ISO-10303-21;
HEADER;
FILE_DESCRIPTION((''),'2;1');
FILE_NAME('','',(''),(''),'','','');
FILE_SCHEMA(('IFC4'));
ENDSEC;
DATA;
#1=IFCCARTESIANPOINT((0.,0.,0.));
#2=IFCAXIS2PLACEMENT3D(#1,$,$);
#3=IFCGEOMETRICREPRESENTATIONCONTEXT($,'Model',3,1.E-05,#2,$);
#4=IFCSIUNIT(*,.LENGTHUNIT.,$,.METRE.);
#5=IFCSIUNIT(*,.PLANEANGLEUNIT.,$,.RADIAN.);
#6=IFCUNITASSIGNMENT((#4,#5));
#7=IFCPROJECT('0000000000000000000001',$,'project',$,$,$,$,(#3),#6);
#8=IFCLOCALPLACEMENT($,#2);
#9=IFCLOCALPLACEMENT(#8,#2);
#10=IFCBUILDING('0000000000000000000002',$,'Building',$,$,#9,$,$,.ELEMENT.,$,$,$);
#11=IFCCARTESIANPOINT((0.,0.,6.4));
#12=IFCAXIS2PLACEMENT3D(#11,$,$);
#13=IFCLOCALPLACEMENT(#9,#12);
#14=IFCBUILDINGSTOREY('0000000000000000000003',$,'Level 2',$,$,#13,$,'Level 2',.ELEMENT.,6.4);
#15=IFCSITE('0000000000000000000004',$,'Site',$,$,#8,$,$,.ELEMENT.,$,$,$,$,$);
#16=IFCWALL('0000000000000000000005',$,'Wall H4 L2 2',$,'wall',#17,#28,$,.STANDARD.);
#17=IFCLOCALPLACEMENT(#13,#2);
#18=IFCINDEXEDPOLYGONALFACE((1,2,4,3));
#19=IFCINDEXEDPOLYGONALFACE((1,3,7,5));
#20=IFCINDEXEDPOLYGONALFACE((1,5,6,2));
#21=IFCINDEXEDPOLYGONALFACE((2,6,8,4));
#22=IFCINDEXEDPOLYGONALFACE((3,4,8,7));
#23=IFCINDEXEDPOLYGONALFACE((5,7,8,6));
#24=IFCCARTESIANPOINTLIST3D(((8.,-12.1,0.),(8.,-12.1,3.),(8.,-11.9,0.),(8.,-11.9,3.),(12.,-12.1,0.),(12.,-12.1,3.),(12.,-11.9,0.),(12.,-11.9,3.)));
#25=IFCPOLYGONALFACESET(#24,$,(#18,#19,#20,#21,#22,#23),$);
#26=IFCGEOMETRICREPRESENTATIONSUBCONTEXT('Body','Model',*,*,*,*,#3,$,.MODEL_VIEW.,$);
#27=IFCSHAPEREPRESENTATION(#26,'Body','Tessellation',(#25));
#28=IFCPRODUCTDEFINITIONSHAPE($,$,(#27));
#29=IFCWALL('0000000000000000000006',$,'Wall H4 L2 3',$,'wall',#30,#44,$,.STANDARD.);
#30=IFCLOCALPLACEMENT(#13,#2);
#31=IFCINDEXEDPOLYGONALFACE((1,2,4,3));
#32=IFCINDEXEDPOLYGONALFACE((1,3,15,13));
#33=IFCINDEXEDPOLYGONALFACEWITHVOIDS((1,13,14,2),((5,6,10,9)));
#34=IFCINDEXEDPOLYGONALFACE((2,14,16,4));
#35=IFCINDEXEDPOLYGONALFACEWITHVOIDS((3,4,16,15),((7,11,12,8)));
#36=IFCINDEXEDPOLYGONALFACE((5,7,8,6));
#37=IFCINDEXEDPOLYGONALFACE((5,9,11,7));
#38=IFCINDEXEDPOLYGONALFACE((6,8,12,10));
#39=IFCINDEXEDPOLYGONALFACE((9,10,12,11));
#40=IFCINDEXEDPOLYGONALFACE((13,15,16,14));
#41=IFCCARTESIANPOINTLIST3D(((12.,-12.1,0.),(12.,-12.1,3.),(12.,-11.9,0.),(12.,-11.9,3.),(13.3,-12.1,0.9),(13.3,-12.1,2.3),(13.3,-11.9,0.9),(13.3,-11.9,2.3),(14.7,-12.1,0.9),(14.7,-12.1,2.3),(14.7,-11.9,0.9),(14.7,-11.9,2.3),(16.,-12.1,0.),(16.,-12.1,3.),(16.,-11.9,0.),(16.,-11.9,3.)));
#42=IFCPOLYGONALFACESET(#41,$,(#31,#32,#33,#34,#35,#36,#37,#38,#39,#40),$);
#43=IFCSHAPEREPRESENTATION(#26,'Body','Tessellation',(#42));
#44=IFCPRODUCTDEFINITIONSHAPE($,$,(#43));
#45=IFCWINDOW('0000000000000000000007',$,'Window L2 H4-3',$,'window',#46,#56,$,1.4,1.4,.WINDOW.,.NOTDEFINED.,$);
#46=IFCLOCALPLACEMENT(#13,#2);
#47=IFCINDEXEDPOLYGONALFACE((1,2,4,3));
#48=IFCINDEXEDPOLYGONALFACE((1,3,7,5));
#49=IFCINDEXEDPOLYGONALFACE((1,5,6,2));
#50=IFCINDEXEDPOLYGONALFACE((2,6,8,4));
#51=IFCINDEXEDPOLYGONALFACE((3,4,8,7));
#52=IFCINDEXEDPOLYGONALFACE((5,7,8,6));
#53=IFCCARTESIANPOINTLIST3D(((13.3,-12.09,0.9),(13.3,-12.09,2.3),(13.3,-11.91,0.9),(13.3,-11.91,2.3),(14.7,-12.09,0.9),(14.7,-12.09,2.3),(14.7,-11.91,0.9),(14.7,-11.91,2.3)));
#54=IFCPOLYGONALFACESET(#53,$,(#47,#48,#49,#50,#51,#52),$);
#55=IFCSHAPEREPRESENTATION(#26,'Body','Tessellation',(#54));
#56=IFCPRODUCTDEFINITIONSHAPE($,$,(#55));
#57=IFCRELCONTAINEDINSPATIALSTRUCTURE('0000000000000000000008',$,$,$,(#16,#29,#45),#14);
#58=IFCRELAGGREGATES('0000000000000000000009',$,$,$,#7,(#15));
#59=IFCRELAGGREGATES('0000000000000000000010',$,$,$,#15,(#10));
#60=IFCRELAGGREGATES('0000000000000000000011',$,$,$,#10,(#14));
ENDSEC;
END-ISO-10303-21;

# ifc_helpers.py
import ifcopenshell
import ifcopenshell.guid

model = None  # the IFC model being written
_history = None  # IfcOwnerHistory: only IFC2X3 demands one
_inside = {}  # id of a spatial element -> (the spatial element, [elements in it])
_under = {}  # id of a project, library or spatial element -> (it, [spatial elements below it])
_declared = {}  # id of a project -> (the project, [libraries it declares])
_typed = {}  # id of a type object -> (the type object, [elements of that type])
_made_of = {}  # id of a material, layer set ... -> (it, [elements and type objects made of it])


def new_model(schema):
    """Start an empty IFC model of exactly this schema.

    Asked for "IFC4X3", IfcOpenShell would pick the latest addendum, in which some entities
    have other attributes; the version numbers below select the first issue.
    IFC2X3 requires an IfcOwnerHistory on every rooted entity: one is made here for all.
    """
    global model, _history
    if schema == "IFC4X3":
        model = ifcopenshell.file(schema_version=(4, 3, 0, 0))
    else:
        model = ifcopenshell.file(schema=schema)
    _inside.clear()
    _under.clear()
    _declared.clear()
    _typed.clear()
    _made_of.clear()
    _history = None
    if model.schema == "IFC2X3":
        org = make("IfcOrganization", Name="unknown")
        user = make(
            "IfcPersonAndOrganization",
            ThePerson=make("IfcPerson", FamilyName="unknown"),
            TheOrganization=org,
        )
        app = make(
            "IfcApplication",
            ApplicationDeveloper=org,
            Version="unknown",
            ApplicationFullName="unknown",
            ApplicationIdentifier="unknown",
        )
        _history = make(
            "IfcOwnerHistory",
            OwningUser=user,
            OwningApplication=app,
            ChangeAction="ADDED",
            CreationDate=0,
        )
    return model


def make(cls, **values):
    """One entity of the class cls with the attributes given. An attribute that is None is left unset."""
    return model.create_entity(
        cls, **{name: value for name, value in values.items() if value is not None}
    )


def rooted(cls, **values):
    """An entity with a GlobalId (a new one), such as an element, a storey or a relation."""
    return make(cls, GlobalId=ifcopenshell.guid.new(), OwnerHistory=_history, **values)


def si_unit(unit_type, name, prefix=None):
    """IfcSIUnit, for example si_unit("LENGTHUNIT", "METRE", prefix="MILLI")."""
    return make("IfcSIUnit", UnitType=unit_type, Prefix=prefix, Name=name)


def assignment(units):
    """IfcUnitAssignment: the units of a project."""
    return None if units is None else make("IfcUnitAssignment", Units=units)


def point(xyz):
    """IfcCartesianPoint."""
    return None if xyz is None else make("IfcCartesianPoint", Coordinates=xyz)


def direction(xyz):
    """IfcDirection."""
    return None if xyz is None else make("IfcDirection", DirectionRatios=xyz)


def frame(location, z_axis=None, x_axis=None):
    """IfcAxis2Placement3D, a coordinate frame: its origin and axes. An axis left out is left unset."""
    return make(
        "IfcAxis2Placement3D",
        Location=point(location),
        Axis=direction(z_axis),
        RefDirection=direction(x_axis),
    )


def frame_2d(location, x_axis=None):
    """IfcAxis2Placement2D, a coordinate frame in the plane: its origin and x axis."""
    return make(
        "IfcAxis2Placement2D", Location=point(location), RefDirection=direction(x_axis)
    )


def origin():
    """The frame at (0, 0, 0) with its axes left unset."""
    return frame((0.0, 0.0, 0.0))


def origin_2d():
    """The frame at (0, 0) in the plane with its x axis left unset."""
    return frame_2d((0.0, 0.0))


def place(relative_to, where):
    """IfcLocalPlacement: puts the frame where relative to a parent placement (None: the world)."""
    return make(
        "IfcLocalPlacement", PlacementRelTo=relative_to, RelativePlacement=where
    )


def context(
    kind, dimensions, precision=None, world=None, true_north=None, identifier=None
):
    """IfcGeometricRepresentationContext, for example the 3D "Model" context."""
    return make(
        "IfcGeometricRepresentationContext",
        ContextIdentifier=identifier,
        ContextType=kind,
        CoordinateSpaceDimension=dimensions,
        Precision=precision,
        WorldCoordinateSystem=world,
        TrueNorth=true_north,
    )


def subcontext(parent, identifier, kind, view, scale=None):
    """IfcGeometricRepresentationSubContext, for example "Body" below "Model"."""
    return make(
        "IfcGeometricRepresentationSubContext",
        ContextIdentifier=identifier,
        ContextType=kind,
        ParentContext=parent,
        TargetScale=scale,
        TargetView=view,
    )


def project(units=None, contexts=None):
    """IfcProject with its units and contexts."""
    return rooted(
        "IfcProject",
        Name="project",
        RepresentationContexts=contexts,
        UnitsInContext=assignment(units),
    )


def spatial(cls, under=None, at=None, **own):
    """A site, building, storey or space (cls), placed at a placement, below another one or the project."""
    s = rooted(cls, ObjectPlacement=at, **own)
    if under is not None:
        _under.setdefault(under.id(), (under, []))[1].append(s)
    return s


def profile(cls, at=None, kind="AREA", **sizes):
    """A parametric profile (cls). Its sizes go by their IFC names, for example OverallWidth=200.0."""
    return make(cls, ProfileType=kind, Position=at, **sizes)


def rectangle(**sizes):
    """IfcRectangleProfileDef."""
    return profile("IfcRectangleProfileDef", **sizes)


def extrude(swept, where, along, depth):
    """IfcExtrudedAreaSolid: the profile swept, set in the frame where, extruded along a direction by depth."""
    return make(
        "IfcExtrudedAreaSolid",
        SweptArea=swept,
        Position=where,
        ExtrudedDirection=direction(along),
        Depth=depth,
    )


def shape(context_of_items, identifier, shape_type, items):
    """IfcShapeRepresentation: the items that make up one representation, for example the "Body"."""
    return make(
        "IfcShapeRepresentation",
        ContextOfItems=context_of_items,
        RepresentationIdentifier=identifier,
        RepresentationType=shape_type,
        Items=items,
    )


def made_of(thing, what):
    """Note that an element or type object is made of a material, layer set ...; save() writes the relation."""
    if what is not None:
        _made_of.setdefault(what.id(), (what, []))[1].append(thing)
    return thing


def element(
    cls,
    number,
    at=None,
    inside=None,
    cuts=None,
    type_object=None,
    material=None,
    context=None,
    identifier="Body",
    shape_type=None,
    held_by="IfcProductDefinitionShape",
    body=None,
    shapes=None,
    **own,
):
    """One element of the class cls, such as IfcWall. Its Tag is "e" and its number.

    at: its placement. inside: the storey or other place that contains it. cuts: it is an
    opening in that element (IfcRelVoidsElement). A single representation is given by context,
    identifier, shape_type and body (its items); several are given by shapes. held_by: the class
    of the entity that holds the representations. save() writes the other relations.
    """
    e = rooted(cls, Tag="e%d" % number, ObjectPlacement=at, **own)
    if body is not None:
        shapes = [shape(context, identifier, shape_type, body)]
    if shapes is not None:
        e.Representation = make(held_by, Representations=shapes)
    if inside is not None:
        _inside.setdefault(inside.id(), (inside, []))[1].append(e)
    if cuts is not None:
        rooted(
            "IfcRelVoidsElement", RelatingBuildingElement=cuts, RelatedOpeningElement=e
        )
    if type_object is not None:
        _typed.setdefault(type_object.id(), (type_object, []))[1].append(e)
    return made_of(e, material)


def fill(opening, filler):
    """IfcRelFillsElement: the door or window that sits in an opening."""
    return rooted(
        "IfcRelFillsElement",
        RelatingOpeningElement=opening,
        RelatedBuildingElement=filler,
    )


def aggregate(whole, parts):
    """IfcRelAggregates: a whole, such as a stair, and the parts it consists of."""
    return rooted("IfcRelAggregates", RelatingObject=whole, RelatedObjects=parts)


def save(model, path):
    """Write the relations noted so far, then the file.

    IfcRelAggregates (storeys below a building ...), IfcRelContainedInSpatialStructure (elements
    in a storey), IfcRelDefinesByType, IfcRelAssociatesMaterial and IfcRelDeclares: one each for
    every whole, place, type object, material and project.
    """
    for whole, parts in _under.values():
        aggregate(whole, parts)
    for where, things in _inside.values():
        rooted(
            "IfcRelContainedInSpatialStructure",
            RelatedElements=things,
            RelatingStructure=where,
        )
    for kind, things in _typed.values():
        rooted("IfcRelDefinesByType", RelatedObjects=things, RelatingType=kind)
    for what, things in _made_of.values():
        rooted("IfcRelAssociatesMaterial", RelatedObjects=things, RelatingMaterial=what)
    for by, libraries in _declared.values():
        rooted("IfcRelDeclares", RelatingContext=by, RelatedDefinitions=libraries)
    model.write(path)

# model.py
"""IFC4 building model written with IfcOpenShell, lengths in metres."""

from ifc_helpers import new_model, si_unit, frame, frame_2d, origin, origin_2d, place, context, subcontext, project, spatial, rectangle, extrude, element, fill, save


model = new_model("IFC4")

# Units and contexts
model_context = context("Model", 3, precision=1e-05, world=origin())
body_context = subcontext(model_context, "Body", "Model", "MODEL_VIEW")
ifc_project = project(units=[si_unit("LENGTHUNIT", "METRE"), si_unit("PLANEANGLEUNIT", "RADIAN")], contexts=[model_context])

# Site, building, storey
site_placement = place(None, origin())
site = spatial("IfcSite", under=ifc_project, at=site_placement, Name="Site", CompositionType="ELEMENT")
building_placement = place(site_placement, origin())
building = spatial("IfcBuilding", under=site, at=building_placement, Name="Building", CompositionType="ELEMENT")
storey_placement = place(building_placement, frame((0.0, 0.0, 6.4)))
storey = spatial("IfcBuildingStorey", under=building, at=storey_placement, Name="Level 2", LongName="Level 2", CompositionType="ELEMENT", Elevation=6.4)

# Wall
for number, where, z_axis, x_axis, name in (
    (1, (8.0, -12.0, 0.0), (0.0, 0.0, 1.0), (1.0, 0.0, 0.0), "Wall H4 L2 2"),
):
    element("IfcWall", number, at=place(storey_placement, frame(where, z_axis=z_axis, x_axis=x_axis)), inside=storey, Name=name, ObjectType="wall", PredefinedType="STANDARD", context=body_context, shape_type="SweptSolid", body=[
        extrude(rectangle(XDim=4.0, YDim=0.2, at=frame_2d((2.0, 0.0))), origin(), (0.0, 0.0, 1.0), 3.0),
    ])

# Wall, opening, window
wall_1_placement = place(storey_placement, frame((12.0, -12.0, 0.0), z_axis=(0.0, 0.0, 1.0), x_axis=(1.0, 0.0, 0.0)))
wall_1 = element("IfcWall", 2, at=wall_1_placement, inside=storey, Name="Wall H4 L2 3", ObjectType="wall", PredefinedType="STANDARD", context=body_context, shape_type="SweptSolid", body=[
    extrude(rectangle(XDim=4.0, YDim=0.2, at=frame_2d((2.0, 0.0))), origin(), (0.0, 0.0, 1.0), 3.0),
])
opening_1_placement = place(storey_placement, frame((14.0, -12.0, 0.9), z_axis=(0.0, 0.0, 1.0), x_axis=(1.0, 0.0, 0.0)))
opening_1 = element("IfcOpeningElement", 3, at=opening_1_placement, cuts=wall_1, ObjectType="Opening", PredefinedType="OPENING", context=body_context, shape_type="SweptSolid", body=[
    extrude(rectangle(XDim=1.4, YDim=0.22, at=origin_2d()), origin(), (0.0, 0.0, 1.0), 1.4),
])
window_1_placement = place(storey_placement, frame((14.0, -12.0, 0.9), z_axis=(0.0, 0.0, 1.0), x_axis=(1.0, 0.0, 0.0)))
window_1 = element("IfcWindow", 4, at=window_1_placement, inside=storey, Name="Window L2 H4-3", ObjectType="window", OverallHeight=1.4, OverallWidth=1.4, PartitioningType="NOTDEFINED", PredefinedType="WINDOW", context=body_context, shape_type="SweptSolid", body=[
    extrude(rectangle(XDim=1.4, YDim=0.18, at=origin_2d()), origin(), (0.0, 0.0, 1.0), 1.4),
])
fill(opening_1, window_1)

save(model, "model.ifc")
